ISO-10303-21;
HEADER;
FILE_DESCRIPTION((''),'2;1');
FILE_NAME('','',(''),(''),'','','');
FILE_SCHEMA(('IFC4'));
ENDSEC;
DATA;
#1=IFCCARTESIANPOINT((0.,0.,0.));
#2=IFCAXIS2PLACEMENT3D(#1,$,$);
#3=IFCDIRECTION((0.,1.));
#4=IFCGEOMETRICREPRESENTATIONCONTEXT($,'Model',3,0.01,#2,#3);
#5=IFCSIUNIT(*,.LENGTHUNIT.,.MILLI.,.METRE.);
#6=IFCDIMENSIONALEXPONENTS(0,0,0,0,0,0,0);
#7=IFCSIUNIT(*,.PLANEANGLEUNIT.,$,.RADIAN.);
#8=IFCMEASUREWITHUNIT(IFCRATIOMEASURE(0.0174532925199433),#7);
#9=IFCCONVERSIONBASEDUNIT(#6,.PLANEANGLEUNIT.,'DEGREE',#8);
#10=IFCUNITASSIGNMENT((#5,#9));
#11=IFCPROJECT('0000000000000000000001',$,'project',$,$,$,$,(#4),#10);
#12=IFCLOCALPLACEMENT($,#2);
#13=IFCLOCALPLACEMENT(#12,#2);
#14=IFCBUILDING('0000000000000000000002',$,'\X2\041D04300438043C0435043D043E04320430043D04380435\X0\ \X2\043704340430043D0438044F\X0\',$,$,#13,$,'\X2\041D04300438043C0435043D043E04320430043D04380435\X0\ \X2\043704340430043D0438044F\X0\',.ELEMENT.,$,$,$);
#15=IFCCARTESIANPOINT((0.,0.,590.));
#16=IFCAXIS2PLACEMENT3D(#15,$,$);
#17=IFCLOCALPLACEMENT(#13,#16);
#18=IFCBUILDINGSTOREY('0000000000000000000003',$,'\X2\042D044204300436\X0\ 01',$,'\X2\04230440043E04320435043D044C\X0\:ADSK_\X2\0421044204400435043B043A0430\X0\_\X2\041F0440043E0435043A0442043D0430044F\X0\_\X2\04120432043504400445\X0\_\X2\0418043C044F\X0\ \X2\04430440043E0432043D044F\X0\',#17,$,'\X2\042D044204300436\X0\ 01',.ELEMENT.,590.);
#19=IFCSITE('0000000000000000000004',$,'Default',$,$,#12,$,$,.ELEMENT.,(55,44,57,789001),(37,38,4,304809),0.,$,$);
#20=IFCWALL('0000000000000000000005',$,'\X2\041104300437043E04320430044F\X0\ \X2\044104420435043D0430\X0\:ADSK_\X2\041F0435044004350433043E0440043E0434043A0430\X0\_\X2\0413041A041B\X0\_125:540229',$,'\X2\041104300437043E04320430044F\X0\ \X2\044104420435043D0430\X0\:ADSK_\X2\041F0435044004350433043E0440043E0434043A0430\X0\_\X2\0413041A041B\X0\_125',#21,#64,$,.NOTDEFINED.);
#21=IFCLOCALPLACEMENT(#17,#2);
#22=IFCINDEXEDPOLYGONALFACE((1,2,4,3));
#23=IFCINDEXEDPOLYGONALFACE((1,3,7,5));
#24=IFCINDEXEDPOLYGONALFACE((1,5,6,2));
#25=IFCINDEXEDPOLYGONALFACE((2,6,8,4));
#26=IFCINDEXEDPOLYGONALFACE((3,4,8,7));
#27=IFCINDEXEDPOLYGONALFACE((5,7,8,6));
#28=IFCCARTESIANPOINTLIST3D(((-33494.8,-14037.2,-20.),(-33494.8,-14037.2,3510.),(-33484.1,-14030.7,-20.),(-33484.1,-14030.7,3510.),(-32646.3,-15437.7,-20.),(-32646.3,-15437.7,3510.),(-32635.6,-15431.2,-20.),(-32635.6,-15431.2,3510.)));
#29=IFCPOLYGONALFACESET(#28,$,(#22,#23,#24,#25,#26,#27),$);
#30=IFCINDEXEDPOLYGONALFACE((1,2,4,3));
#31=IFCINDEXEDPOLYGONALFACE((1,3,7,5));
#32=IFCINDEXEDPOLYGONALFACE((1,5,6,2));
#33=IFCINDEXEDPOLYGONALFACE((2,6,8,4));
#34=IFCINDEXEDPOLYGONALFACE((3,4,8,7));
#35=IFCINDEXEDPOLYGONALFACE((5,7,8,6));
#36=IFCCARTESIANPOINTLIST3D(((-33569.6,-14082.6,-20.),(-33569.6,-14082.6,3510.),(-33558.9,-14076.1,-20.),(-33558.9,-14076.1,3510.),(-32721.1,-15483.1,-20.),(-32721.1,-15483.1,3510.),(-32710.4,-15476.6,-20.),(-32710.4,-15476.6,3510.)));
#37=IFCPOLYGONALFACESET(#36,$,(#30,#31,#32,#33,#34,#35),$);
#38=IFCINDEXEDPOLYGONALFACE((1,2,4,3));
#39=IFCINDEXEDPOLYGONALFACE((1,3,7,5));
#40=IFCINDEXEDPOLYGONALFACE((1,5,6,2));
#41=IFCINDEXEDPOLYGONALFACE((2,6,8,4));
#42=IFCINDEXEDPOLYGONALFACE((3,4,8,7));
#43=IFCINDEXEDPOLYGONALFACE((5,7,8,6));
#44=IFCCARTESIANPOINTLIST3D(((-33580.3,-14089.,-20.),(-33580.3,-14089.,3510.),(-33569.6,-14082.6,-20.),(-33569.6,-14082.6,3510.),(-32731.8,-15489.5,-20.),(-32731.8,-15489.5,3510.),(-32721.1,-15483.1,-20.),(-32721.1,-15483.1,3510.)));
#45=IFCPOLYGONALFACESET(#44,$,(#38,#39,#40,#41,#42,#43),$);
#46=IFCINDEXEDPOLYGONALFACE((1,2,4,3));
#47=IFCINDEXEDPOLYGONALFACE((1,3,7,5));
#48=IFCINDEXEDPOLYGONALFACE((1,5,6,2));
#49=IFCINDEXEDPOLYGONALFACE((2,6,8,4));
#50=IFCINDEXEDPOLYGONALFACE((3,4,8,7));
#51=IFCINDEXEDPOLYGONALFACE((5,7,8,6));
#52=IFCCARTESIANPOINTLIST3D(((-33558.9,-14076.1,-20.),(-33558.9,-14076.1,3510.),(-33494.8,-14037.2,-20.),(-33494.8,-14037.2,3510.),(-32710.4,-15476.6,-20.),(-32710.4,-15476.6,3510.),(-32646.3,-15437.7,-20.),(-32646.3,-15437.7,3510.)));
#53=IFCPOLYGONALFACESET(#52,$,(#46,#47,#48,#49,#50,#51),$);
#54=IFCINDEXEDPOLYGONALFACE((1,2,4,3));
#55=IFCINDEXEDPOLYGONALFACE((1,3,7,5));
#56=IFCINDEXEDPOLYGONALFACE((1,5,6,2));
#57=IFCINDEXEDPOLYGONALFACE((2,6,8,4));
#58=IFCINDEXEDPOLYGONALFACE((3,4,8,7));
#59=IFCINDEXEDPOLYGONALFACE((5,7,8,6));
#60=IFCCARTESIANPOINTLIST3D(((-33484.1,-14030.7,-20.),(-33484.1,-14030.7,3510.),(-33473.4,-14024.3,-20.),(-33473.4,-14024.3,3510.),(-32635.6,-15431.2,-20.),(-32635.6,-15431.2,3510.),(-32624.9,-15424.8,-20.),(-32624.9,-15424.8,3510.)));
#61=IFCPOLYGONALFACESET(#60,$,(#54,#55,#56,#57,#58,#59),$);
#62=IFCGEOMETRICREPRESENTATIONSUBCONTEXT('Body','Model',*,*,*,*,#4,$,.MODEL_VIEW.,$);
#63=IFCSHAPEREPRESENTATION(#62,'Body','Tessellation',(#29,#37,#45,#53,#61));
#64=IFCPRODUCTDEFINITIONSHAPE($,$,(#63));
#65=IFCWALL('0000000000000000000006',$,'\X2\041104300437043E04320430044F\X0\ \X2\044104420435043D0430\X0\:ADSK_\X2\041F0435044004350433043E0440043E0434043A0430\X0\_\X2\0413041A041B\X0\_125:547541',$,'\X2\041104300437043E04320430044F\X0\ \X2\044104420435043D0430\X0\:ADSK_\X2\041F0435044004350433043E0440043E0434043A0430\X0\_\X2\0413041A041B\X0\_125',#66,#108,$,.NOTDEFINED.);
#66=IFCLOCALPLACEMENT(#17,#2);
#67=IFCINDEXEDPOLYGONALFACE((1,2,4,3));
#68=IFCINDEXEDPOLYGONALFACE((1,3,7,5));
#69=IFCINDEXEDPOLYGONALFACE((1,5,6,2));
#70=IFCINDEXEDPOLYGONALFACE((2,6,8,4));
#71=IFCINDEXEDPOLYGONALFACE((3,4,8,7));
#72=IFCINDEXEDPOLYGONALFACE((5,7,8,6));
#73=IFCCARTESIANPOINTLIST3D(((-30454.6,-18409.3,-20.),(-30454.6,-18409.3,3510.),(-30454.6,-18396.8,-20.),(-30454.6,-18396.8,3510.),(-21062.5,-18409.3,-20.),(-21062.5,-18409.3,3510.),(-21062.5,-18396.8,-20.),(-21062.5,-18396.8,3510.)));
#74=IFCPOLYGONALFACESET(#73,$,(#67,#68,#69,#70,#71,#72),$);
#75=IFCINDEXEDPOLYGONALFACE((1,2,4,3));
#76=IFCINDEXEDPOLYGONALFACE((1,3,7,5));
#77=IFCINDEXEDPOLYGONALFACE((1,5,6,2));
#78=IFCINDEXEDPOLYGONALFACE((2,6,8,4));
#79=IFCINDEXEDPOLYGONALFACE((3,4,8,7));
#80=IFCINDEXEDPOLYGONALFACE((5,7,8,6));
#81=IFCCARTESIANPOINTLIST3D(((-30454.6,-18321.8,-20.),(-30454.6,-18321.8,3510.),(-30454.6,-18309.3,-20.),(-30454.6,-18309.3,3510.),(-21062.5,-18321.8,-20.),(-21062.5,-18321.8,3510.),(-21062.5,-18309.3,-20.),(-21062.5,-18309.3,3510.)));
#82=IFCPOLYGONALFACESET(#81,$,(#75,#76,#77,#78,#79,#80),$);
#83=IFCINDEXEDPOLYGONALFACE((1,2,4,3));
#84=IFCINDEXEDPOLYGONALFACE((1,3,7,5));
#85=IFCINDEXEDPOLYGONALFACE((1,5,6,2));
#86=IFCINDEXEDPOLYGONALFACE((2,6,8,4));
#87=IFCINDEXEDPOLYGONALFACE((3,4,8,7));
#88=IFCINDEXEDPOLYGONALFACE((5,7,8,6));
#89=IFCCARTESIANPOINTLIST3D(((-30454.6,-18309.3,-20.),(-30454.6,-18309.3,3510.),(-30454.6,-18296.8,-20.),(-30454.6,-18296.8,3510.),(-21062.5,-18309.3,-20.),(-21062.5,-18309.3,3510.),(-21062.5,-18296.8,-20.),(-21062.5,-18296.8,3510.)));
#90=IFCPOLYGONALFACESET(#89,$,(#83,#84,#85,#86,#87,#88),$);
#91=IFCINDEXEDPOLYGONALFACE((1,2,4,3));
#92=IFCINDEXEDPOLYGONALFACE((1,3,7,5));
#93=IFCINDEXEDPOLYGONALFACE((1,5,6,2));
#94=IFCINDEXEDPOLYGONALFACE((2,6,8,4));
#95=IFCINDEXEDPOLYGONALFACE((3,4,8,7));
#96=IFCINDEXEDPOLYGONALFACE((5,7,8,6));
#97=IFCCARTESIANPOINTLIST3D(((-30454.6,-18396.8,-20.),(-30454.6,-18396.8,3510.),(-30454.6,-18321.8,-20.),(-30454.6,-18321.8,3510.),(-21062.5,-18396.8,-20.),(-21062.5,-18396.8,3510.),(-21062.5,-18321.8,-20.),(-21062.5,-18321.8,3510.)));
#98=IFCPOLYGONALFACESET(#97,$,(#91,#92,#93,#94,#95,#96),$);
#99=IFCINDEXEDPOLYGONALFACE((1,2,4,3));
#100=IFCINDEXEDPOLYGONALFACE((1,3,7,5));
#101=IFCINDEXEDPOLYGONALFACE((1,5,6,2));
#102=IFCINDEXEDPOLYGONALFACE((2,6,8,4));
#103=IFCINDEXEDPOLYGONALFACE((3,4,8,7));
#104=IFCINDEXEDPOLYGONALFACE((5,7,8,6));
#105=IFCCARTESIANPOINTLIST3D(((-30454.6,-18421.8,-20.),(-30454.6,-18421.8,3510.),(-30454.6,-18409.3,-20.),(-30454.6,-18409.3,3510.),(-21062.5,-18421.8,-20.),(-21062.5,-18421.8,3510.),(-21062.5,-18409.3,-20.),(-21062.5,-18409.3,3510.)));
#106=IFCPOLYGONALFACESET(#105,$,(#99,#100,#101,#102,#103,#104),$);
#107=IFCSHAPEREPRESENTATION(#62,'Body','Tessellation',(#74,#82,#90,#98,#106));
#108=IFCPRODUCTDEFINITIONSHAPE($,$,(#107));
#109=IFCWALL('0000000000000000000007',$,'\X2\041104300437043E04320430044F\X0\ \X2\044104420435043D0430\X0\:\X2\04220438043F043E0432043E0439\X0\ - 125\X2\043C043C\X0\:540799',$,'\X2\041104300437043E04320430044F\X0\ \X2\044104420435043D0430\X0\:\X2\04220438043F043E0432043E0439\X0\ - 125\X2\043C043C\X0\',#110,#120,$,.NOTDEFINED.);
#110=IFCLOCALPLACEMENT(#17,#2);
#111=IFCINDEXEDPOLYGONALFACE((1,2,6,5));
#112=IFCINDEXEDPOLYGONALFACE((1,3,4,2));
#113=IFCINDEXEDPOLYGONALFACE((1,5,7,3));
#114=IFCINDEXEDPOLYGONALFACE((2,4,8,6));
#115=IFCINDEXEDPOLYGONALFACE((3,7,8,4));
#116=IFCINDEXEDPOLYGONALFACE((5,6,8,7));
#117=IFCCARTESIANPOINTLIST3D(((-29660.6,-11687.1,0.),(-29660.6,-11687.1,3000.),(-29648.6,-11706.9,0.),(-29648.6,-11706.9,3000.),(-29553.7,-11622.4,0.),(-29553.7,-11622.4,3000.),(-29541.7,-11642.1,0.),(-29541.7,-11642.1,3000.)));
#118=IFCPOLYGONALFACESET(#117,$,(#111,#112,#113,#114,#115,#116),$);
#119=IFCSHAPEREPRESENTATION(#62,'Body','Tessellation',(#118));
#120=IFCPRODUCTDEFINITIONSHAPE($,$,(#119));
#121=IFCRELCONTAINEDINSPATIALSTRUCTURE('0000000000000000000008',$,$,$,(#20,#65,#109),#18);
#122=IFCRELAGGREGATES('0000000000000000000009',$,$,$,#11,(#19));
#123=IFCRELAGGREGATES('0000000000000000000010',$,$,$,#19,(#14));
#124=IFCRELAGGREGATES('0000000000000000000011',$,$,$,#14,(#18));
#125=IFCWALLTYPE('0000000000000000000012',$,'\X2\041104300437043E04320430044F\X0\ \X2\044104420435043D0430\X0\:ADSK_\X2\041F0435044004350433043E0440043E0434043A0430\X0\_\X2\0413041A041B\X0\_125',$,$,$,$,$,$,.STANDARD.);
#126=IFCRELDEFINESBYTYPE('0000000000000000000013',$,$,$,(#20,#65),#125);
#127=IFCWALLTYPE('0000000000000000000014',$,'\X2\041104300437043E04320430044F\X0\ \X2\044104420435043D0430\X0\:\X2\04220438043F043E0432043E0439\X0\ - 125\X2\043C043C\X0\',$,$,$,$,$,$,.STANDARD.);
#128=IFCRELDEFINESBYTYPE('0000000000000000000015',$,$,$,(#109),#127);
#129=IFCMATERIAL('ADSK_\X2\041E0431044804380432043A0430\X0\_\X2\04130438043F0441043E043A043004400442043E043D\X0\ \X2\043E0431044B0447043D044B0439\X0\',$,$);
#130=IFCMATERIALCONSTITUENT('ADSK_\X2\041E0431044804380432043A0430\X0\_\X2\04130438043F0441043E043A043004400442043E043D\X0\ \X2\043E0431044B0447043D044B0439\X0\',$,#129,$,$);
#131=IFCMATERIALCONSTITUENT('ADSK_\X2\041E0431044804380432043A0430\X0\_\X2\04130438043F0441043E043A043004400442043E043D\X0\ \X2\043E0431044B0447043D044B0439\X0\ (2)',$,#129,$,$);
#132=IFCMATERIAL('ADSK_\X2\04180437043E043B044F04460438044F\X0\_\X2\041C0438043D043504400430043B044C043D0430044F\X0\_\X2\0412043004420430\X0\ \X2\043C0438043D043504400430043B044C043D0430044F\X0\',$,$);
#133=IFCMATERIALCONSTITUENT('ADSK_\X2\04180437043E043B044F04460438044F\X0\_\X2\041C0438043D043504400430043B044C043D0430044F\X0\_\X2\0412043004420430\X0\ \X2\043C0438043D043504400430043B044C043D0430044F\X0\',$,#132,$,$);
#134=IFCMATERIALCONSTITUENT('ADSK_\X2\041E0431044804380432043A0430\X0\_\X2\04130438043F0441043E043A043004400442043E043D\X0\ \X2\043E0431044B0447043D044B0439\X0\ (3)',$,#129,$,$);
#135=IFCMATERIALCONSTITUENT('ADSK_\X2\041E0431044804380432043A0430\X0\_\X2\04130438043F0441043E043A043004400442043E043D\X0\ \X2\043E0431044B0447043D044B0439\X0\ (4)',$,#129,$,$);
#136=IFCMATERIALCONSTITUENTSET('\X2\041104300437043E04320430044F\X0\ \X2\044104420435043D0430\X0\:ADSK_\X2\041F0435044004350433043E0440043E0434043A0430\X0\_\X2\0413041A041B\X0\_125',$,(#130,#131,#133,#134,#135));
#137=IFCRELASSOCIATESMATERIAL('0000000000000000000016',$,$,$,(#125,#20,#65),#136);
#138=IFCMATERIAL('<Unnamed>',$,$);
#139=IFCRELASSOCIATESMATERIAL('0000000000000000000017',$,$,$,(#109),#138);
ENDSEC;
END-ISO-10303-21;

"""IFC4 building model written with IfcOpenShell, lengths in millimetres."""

from ifc_helpers import new_model, entity, si_unit, converted_unit, direction, frame, origin, place, context, subcontext, project, spatial, indexed_curve, outline, extrude, material, constituent, constituent_set, type_object, element, save


model = new_model("IFC4")

# Units and contexts
model_context = context("Model", 3, precision=0.01, world=origin(), true_north=direction((0.0, 1.0)))
body_context = subcontext(model_context, "Body", "Model", "MODEL_VIEW")
ifc_project = project(units=[si_unit("LENGTHUNIT", "METRE", prefix="MILLI"), converted_unit("PLANEANGLEUNIT", "DEGREE", entity("IfcRatioMeasure", 0.0174532925199433), si_unit("PLANEANGLEUNIT", "RADIAN"), dimensions=[0, 0, 0, 0, 0, 0, 0])], contexts=[model_context])

# Site, building, storey
site_placement = place(None, origin())
site = spatial("IfcSite", under=ifc_project, at=site_placement, Name="Default", CompositionType="ELEMENT", RefLatitude=(55, 44, 57, 789001), RefLongitude=(37, 38, 4, 304809), RefElevation=0.0)
building_placement = place(site_placement, origin())
building = spatial("IfcBuilding", under=site, at=building_placement, Name="Наименование здания", LongName="Наименование здания", CompositionType="ELEMENT")
storey_placement = place(building_placement, frame((0.0, 0.0, 590.0)))
storey = spatial("IfcBuildingStorey", under=building, at=storey_placement, Name="Этаж 01", ObjectType="Уровень:ADSK_Стрелка_Проектная_Вверх_Имя уровня", LongName="Этаж 01", CompositionType="ELEMENT", Elevation=590.0)

# Shared definitions
ifc_material_1 = material(Name="<Unnamed>")

# Walls
ifc_material_2 = material(Name="ADSK_Обшивка_Гипсокартон обычный")
ifc_constituent_1 = constituent(ifc_material_2, Name="ADSK_Обшивка_Гипсокартон обычный")
ifc_constituent_2 = constituent(ifc_material_2, Name="ADSK_Обшивка_Гипсокартон обычный (2)")
ifc_material_3 = material(Name="ADSK_Изоляция_Минеральная_Вата минеральная")
ifc_constituent_3 = constituent(ifc_material_3, Name="ADSK_Изоляция_Минеральная_Вата минеральная")
ifc_constituent_4 = constituent(ifc_material_2, Name="ADSK_Обшивка_Гипсокартон обычный (3)")
ifc_constituent_5 = constituent(ifc_material_2, Name="ADSK_Обшивка_Гипсокартон обычный (4)")
ifc_constituent_set = constituent_set(constituents=[ifc_constituent_1, ifc_constituent_2, ifc_constituent_3, ifc_constituent_4, ifc_constituent_5], Name="Базовая стена:ADSK_Перегородка_ГКЛ_125")
wall_type_1 = type_object("IfcWallType", Name="Базовая стена:ADSK_Перегородка_ГКЛ_125", PredefinedType="STANDARD", material=ifc_constituent_set)
wall_1_placement = place(storey_placement, frame((-32678.3, -15457.1, -20.0), z_axis=(0.0, 0.0, 1.0), x_axis=(-0.518188, 0.855267, 0.0)))
element("IfcWall", 1, at=wall_1_placement, inside=storey, type_object=wall_type_1, material=ifc_constituent_set, Name="Базовая стена:ADSK_Перегородка_ГКЛ_125:540229", ObjectType="Базовая стена:ADSK_Перегородка_ГКЛ_125", PredefinedType="NOTDEFINED", context=body_context, shape_type="SweptSolid", body=[
    extrude(outline(indexed_curve([(-818.7, -6.2), (818.7, -6.3), (818.7, 6.2), (-818.7, 6.3), (-818.7, -6.2)], self_intersect=False)), frame((818.7, -43.8, 0.0)), (0.0, 0.0, 1.0), 3530.0),
    extrude(outline(indexed_curve([(-818.7, -6.2), (818.7, -6.2), (818.7, 6.3), (-818.7, 6.3), (-818.7, -6.2)], self_intersect=False)), frame((818.7, 43.7, 0.0)), (0.0, 0.0, 1.0), 3530.0),
    extrude(outline(indexed_curve([(-6.2, -818.7), (6.3, -818.7), (6.2, 818.7), (-6.3, 818.7), (-6.2, -818.7)], self_intersect=False)), frame((818.7, 56.2, 0.0), z_axis=(0.0, 0.0, 1.0), x_axis=(0.0, -1.0, 0.0)), (0.0, 0.0, 1.0), 3530.0),
    extrude(outline(indexed_curve([(-818.7, -37.5), (818.7, -37.5), (818.7, 37.5), (-818.7, 37.5), (-818.7, -37.5)], self_intersect=False)), frame((818.7, 0.0, 0.0)), (0.0, 0.0, 1.0), 3530.0),
    extrude(outline(indexed_curve([(-6.3, -818.7), (6.2, -818.7), (6.3, 818.7), (-6.2, 818.7), (-6.3, -818.7)], self_intersect=False)), frame((818.7, -56.3, 0.0), z_axis=(0.0, 0.0, 1.0), x_axis=(0.0, 1.0, 0.0)), (0.0, 0.0, 1.0), 3530.0),
])
wall_2_placement = place(storey_placement, frame((-30454.6, -18359.3, -20.0)))
element("IfcWall", 2, at=wall_2_placement, inside=storey, type_object=wall_type_1, material=ifc_constituent_set, Name="Базовая стена:ADSK_Перегородка_ГКЛ_125:547541", ObjectType="Базовая стена:ADSK_Перегородка_ГКЛ_125", PredefinedType="NOTDEFINED", context=body_context, shape_type="SweptSolid", body=[
    extrude(outline(indexed_curve([(-4696.1, -6.2), (4696.1, -6.2), (4696.1, 6.3), (-4696.1, 6.3), (-4696.1, -6.2)], self_intersect=False)), frame((4696.1, -43.8, 0.0)), (0.0, 0.0, 1.0), 3530.0),
    extrude(outline(indexed_curve([(-4696.1, -6.3), (4696.1, -6.3), (4696.1, 6.2), (-4696.1, 6.2), (-4696.1, -6.3)], self_intersect=False)), frame((4696.1, 43.8, 0.0)), (0.0, 0.0, 1.0), 3530.0),
    extrude(outline(indexed_curve([(-6.3, -4696.1), (6.3, -4696.1), (6.3, 4696.1), (-6.3, 4696.1), (-6.3, -4696.1)], self_intersect=False)), frame((4696.1, 56.3, 0.0), z_axis=(0.0, 0.0, 1.0), x_axis=(0.0, -1.0, 0.0)), (0.0, 0.0, 1.0), 3530.0),
    extrude(outline(indexed_curve([(-4696.1, -37.5), (4696.1, -37.5), (4696.1, 37.5), (-4696.1, 37.5), (-4696.1, -37.5)], self_intersect=False)), frame((4696.1, 0.0, 0.0)), (0.0, 0.0, 1.0), 3530.0),
    extrude(outline(indexed_curve([(-6.3, -4696.1), (6.2, -4696.1), (6.2, 4696.1), (-6.3, 4696.1), (-6.3, -4696.1)], self_intersect=False)), frame((4696.1, -56.2, 0.0), z_axis=(0.0, 0.0, 1.0), x_axis=(0.0, 1.0, 0.0)), (0.0, 0.0, 1.0), 3530.0),
])
wall_type_2 = type_object("IfcWallType", Name="Базовая стена:Типовой - 125мм", PredefinedType="STANDARD")
wall_3_placement = place(storey_placement, frame((-29595.1, -11674.5, 0.0), z_axis=(0.0, 0.0, 1.0), x_axis=(-0.518188, 0.855267, 0.0)))
element("IfcWall", 3, at=wall_3_placement, inside=storey, type_object=wall_type_2, material=ifc_material_1, Name="Базовая стена:Типовой - 125мм:540799", ObjectType="Базовая стена:Типовой - 125мм", PredefinedType="NOTDEFINED", context=body_context, shape_type="SweptSolid", body=[
    extrude(outline(indexed_curve([(23.1, 62.5), (0.0, 62.5), (0.0, -62.5), (23.1, -62.5), (23.1, 62.5)], self_intersect=False)), origin(), (0.0, 0.0, 1.0), 3000.0),
])

save(model, "model.ifc")
